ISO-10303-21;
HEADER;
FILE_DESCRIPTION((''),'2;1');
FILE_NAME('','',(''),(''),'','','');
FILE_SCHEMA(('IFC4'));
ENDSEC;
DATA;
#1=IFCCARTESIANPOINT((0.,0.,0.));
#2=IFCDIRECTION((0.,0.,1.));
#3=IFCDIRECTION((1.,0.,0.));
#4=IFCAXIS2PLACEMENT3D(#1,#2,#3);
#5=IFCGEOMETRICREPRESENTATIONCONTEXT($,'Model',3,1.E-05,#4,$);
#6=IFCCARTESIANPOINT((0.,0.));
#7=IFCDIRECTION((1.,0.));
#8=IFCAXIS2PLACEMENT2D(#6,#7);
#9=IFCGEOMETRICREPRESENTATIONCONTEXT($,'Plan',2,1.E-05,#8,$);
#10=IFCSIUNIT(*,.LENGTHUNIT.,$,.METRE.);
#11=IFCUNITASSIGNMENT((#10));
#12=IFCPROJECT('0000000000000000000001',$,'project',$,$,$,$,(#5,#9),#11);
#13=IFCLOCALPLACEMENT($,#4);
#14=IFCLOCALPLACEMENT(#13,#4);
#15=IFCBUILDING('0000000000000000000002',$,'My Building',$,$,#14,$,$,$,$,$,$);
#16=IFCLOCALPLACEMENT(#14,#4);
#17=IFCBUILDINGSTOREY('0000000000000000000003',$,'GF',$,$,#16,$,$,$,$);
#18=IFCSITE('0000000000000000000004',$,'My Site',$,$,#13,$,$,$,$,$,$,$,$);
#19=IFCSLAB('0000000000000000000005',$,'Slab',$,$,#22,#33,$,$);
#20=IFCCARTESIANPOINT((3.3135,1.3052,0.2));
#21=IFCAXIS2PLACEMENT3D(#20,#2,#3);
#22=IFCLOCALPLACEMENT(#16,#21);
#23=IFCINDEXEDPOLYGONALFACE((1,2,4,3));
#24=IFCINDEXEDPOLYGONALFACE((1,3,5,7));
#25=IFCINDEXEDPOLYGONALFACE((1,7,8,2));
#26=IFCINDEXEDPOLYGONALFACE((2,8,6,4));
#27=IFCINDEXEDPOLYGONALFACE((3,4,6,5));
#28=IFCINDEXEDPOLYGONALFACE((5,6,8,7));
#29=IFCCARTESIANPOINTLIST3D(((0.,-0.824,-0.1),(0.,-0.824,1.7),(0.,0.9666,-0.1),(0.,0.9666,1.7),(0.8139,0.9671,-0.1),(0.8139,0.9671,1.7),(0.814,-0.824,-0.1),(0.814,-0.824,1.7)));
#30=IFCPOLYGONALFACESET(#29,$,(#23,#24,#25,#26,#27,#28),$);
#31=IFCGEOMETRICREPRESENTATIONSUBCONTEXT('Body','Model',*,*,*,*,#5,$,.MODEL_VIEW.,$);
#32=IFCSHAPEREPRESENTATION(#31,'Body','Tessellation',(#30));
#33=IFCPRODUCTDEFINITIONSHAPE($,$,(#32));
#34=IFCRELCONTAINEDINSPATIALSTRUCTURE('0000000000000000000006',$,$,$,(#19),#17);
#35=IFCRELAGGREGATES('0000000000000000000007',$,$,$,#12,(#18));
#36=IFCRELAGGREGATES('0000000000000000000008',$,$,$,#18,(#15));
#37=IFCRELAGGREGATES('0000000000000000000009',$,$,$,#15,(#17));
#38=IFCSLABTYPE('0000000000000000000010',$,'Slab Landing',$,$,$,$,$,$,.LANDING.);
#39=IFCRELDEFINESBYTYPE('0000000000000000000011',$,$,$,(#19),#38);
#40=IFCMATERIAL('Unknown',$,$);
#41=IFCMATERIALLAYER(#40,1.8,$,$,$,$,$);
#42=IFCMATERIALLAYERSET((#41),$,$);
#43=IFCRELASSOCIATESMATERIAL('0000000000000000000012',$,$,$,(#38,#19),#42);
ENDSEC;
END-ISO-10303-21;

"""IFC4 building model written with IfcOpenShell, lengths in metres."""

from ifc_helpers import new_model, si_unit, frame, origin_with_axes, origin_2d_with_axis, place, context, subcontext, project, spatial, indexed_curve, outline, extrude, material, layer, layer_set, layer_usage, type_object, element, save


model = new_model("IFC4")

# Units and contexts
model_context = context("Model", 3, precision=1e-05, world=origin_with_axes())
plan_context = context("Plan", 2, precision=1e-05, world=origin_2d_with_axis())
body_context_1 = subcontext(model_context, "Body", "Model", "MODEL_VIEW")
ifc_project = project(units=[si_unit("LENGTHUNIT", "METRE")], contexts=[model_context, plan_context])

# Site, building, storey
site_placement = place(None, origin_with_axes())
site = spatial("IfcSite", under=ifc_project, at=site_placement, Name="My Site")
building_placement = place(site_placement, origin_with_axes())
building = spatial("IfcBuilding", under=site, at=building_placement, Name="My Building")
storey_placement = place(building_placement, origin_with_axes())
storey = spatial("IfcBuildingStorey", under=building, at=storey_placement, Name="GF")

# Shared definitions
ifc_material = material(Name="Unknown")

# Slab
ifc_layer_1 = layer(ifc_material, 1.8)
ifc_layer_set_1 = layer_set([ifc_layer_1])
ifc_layer_usage_1 = layer_usage(ifc_layer_set_1, "AXIS3", "POSITIVE", -0.1)
slab_type = type_object("IfcSlabType", Name="Slab Landing", PredefinedType="LANDING", material=ifc_layer_set_1)
slab_1_placement = place(storey_placement, frame((3.3135, 1.3052, 0.2), z_axis=(0.0, 0.0, 1.0), x_axis=(1.0, 0.0, 0.0)))
element("IfcSlab", 1, at=slab_1_placement, inside=storey, type_object=slab_type, material=ifc_layer_usage_1, Name="Slab", context=body_context_1, shape_type="SweptSolid", body=[
    extrude(outline(indexed_curve([(0.0, 0.9666), (0.0, -0.824), (0.814, -0.824), (0.8139, 0.9671), (0.0, 0.9666)])), frame((0.0, 0.0, -0.1), z_axis=(0.0, 0.0, 1.0), x_axis=(1.0, 0.0, 0.0)), (0.0, 0.0, 1.0), 1.8),
])

save(model, "model.ifc")
